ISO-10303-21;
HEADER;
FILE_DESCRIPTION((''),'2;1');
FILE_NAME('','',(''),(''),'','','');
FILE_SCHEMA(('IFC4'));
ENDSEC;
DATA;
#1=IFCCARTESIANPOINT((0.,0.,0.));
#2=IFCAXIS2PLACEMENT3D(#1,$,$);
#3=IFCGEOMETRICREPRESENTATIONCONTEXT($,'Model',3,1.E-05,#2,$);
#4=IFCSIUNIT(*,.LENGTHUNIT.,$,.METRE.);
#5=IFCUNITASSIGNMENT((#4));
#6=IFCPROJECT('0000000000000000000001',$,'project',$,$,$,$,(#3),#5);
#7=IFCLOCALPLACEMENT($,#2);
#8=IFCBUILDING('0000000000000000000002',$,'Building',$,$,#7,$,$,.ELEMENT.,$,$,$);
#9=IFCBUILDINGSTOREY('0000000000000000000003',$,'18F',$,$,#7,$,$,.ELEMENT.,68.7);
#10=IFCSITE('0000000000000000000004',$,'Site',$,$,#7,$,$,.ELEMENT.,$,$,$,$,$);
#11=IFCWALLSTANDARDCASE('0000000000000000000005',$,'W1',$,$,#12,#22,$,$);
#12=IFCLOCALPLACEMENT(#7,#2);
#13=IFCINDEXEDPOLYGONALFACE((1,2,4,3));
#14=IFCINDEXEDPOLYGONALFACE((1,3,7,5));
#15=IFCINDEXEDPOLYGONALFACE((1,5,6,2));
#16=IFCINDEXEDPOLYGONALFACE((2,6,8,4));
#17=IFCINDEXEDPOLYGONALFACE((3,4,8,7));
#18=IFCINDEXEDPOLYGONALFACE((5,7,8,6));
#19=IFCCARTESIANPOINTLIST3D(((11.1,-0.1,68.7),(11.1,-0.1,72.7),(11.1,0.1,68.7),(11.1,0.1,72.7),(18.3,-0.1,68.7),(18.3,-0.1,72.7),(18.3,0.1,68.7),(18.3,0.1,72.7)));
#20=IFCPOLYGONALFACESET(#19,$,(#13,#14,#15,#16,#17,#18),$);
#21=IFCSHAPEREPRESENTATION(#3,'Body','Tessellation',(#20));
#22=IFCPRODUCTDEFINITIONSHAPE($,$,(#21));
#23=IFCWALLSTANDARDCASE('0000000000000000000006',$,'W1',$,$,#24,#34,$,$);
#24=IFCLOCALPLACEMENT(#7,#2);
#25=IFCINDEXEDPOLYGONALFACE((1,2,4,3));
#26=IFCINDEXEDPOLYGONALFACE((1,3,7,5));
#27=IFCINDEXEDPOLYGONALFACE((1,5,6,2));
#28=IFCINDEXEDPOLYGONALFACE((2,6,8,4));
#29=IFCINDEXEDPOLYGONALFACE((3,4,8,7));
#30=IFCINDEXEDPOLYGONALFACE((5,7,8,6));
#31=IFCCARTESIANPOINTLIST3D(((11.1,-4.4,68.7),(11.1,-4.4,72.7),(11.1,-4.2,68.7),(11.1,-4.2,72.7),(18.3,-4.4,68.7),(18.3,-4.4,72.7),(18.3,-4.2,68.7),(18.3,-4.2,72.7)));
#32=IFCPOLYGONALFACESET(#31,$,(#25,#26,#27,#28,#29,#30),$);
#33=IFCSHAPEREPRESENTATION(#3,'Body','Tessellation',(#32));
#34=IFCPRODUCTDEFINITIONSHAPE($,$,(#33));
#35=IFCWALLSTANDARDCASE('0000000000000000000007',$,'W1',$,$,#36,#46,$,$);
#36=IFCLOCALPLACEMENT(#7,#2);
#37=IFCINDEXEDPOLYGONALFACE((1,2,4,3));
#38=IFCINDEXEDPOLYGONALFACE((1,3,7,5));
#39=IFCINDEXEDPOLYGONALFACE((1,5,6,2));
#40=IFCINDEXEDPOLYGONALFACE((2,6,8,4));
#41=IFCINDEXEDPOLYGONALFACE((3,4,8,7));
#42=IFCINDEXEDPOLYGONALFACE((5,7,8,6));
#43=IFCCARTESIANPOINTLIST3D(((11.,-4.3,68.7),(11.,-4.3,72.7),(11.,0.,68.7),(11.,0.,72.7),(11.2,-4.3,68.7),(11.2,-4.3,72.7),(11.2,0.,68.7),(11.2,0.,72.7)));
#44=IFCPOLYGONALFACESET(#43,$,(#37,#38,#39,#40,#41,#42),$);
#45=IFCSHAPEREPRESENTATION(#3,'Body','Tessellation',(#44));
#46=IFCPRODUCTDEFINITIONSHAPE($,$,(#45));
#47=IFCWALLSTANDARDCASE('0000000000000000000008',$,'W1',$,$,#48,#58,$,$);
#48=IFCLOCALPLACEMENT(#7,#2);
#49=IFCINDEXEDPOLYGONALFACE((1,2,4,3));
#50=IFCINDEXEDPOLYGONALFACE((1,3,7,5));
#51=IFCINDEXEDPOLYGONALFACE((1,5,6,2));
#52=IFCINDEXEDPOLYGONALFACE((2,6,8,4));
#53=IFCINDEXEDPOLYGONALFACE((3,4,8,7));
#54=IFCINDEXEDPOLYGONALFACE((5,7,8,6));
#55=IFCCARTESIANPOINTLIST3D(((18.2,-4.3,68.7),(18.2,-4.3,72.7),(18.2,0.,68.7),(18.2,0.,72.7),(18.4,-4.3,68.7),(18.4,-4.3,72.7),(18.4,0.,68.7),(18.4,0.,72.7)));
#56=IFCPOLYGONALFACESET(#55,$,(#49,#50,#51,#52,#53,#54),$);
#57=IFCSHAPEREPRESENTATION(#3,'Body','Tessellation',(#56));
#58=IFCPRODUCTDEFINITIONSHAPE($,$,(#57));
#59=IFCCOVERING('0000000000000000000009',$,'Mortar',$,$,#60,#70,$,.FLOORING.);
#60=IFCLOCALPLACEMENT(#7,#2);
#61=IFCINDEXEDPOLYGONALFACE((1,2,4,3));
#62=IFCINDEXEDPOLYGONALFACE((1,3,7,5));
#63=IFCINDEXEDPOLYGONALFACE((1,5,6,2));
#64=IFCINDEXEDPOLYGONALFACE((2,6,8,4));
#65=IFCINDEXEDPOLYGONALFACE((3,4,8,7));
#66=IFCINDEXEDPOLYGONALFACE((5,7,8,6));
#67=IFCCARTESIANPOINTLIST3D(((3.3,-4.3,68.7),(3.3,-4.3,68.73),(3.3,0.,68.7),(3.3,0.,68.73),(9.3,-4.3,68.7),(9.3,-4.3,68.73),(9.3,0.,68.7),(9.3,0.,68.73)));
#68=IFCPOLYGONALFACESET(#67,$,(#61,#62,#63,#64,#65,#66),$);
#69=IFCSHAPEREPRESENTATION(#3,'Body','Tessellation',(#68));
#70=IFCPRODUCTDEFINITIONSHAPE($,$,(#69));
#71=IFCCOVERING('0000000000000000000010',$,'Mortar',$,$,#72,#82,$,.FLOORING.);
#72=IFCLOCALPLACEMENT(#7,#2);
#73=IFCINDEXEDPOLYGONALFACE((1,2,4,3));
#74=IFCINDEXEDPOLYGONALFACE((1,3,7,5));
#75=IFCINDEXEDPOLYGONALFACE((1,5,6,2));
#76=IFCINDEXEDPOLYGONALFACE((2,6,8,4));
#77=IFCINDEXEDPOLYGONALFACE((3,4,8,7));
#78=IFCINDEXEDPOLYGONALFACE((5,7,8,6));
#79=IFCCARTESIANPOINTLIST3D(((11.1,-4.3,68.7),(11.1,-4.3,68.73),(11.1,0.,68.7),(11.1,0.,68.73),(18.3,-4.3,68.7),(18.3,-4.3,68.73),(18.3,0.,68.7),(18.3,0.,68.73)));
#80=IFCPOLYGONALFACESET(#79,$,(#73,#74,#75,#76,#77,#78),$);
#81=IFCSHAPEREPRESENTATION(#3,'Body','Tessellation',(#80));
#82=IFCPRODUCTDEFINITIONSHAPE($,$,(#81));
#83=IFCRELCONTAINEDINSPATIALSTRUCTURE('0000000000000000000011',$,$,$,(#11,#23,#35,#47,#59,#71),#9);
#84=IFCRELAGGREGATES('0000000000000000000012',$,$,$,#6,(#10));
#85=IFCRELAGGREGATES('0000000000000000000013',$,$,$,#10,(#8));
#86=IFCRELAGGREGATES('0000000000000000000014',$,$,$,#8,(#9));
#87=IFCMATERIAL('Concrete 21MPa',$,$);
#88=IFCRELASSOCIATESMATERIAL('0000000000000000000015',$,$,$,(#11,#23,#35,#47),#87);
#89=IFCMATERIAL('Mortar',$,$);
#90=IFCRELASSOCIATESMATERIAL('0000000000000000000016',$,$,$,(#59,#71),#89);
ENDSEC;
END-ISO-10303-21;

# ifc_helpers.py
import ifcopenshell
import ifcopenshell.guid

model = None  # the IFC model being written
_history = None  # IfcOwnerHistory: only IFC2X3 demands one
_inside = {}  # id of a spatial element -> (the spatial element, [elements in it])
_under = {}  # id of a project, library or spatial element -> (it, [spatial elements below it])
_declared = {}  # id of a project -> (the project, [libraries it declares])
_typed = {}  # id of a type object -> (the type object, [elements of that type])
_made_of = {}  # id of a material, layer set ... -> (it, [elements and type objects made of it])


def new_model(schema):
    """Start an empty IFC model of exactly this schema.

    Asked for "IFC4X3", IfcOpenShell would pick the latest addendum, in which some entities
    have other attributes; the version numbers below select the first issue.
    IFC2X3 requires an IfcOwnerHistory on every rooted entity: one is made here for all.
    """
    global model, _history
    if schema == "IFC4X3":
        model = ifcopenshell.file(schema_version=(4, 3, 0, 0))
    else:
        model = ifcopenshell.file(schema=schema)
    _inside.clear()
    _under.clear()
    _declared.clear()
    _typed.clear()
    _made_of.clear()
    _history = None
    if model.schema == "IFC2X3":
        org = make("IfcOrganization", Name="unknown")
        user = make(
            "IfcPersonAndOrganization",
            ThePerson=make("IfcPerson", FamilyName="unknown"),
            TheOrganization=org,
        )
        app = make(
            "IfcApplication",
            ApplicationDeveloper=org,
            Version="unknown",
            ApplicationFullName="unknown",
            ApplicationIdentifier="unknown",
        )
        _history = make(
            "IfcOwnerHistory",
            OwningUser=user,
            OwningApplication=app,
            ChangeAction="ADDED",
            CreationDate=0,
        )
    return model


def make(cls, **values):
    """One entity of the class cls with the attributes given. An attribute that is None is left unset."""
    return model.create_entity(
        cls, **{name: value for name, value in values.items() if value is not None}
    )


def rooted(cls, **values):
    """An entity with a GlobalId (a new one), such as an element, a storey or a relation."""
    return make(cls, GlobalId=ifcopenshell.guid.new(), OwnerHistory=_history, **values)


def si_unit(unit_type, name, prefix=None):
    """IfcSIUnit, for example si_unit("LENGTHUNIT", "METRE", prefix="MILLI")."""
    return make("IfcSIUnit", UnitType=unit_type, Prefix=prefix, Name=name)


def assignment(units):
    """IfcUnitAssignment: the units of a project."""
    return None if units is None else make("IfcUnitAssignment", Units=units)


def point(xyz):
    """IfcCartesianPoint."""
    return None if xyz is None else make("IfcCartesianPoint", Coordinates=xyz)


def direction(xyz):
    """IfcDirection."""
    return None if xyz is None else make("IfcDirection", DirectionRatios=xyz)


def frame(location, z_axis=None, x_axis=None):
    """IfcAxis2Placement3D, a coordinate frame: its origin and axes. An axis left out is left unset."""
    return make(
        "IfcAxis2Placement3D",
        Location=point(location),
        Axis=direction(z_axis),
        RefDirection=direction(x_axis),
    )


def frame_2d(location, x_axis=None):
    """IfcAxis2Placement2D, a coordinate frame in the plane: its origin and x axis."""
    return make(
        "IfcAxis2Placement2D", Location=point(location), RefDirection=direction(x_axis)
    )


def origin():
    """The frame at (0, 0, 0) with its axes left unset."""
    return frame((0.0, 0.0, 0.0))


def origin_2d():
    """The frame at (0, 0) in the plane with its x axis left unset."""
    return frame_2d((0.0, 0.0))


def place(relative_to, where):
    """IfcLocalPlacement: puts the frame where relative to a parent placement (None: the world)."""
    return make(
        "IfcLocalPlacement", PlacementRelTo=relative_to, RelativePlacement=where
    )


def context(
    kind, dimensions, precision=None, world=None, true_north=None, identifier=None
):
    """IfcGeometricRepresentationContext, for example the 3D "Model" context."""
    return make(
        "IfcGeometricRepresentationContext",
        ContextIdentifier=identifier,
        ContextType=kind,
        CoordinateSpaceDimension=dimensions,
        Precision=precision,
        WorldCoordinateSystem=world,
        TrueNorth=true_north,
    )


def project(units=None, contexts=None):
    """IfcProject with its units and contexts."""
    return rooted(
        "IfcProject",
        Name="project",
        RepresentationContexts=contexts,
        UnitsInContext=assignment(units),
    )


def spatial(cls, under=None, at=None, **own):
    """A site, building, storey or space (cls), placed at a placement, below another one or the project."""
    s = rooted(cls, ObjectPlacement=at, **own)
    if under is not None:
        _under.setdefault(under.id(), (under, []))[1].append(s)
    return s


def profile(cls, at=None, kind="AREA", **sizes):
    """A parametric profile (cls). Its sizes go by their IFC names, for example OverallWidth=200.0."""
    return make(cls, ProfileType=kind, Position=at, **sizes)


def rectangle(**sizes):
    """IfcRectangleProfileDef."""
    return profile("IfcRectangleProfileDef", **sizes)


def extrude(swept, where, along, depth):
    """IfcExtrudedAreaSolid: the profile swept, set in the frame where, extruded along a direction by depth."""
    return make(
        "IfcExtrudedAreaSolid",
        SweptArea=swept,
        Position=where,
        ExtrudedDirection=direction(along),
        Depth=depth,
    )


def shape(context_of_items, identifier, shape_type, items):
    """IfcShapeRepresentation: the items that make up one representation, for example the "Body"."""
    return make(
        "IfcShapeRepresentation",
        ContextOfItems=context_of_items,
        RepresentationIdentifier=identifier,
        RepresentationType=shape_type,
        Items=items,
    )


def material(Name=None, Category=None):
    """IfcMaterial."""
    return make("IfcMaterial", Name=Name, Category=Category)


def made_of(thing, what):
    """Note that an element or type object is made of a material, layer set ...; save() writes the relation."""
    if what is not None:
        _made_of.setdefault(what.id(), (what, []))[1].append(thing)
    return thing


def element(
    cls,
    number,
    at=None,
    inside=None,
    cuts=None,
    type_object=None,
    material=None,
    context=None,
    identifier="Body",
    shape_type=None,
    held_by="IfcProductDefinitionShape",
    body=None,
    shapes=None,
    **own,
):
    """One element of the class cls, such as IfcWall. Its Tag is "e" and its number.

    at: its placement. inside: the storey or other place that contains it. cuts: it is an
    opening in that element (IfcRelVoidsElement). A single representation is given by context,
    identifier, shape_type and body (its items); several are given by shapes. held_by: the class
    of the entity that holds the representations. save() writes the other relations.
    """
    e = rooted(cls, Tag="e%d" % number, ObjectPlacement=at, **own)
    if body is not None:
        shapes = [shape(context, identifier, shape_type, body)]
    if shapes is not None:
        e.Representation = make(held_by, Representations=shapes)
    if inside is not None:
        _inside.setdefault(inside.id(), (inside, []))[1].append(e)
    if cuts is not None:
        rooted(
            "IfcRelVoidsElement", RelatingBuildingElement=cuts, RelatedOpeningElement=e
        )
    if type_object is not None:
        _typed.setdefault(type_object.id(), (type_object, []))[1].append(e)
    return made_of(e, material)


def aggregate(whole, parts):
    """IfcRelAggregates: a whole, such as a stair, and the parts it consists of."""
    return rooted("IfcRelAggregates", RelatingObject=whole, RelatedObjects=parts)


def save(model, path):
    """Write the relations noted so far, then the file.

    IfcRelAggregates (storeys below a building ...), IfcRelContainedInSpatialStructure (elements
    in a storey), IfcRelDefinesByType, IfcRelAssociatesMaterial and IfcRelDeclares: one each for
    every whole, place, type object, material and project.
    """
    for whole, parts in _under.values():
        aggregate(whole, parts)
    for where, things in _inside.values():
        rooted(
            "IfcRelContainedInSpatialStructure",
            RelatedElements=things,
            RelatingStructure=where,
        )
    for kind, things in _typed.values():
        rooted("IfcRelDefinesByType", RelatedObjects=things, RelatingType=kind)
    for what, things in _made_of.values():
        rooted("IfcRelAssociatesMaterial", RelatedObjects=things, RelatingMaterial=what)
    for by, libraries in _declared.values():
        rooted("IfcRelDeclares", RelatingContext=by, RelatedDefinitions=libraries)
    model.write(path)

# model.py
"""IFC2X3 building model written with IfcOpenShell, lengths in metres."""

from ifc_helpers import new_model, si_unit, frame, origin, origin_2d, place, context, project, spatial, rectangle, extrude, material, element, save


model = new_model("IFC2X3")

# Units and contexts
model_context = context("Model", 3, precision=1e-05, world=origin())
ifc_project = project(units=[si_unit("LENGTHUNIT", "METRE")], contexts=[model_context])

# Site, building, storey
placement = place(None, origin())
site = spatial("IfcSite", under=ifc_project, at=placement, Name="Site", CompositionType="ELEMENT")
building = spatial("IfcBuilding", under=site, at=placement, Name="Building", CompositionType="ELEMENT")
storey = spatial("IfcBuildingStorey", under=building, at=placement, Name="18F", CompositionType="ELEMENT", Elevation=68.7)

# Shared definitions
ifc_material_1 = material(Name="Concrete 21MPa")

# Walls
for number, where, name in (
    (1, (14.7, 0.0, 68.7), "W1"),
    (2, (14.7, -4.3, 68.7), "W1"),
):
    element("IfcWallStandardCase", number, at=place(None, frame(where)), inside=storey, material=ifc_material_1, Name=name, context=model_context, shape_type="SweptSolid", body=[
        extrude(rectangle(XDim=7.2, YDim=0.2, at=origin_2d()), origin(), (0.0, 0.0, 1.0), 4.0),
    ])
for number, where, name in (
    (3, (11.1, -2.15, 68.7), "W1"),
    (4, (18.3, -2.15, 68.7), "W1"),
):
    element("IfcWallStandardCase", number, at=place(None, frame(where)), inside=storey, material=ifc_material_1, Name=name, context=model_context, shape_type="SweptSolid", body=[
        extrude(rectangle(XDim=0.2, YDim=4.3, at=origin_2d()), origin(), (0.0, 0.0, 1.0), 4.0),
    ])

# Coverings
ifc_material_2 = material(Name="Mortar")
covering_1_placement = place(None, frame((6.3, -2.15, 68.7)))
element("IfcCovering", 5, at=covering_1_placement, inside=storey, material=ifc_material_2, Name="Mortar", PredefinedType="FLOORING", context=model_context, shape_type="SweptSolid", body=[
    extrude(rectangle(XDim=6.0, YDim=4.3, at=origin_2d()), origin(), (0.0, 0.0, 1.0), 0.03),
])
covering_2_placement = place(None, frame((14.7, -2.15, 68.7)))
element("IfcCovering", 6, at=covering_2_placement, inside=storey, material=ifc_material_2, Name="Mortar", PredefinedType="FLOORING", context=model_context, shape_type="SweptSolid", body=[
    extrude(rectangle(XDim=7.2, YDim=4.3, at=origin_2d()), origin(), (0.0, 0.0, 1.0), 0.03),
])

save(model, "model.ifc")
